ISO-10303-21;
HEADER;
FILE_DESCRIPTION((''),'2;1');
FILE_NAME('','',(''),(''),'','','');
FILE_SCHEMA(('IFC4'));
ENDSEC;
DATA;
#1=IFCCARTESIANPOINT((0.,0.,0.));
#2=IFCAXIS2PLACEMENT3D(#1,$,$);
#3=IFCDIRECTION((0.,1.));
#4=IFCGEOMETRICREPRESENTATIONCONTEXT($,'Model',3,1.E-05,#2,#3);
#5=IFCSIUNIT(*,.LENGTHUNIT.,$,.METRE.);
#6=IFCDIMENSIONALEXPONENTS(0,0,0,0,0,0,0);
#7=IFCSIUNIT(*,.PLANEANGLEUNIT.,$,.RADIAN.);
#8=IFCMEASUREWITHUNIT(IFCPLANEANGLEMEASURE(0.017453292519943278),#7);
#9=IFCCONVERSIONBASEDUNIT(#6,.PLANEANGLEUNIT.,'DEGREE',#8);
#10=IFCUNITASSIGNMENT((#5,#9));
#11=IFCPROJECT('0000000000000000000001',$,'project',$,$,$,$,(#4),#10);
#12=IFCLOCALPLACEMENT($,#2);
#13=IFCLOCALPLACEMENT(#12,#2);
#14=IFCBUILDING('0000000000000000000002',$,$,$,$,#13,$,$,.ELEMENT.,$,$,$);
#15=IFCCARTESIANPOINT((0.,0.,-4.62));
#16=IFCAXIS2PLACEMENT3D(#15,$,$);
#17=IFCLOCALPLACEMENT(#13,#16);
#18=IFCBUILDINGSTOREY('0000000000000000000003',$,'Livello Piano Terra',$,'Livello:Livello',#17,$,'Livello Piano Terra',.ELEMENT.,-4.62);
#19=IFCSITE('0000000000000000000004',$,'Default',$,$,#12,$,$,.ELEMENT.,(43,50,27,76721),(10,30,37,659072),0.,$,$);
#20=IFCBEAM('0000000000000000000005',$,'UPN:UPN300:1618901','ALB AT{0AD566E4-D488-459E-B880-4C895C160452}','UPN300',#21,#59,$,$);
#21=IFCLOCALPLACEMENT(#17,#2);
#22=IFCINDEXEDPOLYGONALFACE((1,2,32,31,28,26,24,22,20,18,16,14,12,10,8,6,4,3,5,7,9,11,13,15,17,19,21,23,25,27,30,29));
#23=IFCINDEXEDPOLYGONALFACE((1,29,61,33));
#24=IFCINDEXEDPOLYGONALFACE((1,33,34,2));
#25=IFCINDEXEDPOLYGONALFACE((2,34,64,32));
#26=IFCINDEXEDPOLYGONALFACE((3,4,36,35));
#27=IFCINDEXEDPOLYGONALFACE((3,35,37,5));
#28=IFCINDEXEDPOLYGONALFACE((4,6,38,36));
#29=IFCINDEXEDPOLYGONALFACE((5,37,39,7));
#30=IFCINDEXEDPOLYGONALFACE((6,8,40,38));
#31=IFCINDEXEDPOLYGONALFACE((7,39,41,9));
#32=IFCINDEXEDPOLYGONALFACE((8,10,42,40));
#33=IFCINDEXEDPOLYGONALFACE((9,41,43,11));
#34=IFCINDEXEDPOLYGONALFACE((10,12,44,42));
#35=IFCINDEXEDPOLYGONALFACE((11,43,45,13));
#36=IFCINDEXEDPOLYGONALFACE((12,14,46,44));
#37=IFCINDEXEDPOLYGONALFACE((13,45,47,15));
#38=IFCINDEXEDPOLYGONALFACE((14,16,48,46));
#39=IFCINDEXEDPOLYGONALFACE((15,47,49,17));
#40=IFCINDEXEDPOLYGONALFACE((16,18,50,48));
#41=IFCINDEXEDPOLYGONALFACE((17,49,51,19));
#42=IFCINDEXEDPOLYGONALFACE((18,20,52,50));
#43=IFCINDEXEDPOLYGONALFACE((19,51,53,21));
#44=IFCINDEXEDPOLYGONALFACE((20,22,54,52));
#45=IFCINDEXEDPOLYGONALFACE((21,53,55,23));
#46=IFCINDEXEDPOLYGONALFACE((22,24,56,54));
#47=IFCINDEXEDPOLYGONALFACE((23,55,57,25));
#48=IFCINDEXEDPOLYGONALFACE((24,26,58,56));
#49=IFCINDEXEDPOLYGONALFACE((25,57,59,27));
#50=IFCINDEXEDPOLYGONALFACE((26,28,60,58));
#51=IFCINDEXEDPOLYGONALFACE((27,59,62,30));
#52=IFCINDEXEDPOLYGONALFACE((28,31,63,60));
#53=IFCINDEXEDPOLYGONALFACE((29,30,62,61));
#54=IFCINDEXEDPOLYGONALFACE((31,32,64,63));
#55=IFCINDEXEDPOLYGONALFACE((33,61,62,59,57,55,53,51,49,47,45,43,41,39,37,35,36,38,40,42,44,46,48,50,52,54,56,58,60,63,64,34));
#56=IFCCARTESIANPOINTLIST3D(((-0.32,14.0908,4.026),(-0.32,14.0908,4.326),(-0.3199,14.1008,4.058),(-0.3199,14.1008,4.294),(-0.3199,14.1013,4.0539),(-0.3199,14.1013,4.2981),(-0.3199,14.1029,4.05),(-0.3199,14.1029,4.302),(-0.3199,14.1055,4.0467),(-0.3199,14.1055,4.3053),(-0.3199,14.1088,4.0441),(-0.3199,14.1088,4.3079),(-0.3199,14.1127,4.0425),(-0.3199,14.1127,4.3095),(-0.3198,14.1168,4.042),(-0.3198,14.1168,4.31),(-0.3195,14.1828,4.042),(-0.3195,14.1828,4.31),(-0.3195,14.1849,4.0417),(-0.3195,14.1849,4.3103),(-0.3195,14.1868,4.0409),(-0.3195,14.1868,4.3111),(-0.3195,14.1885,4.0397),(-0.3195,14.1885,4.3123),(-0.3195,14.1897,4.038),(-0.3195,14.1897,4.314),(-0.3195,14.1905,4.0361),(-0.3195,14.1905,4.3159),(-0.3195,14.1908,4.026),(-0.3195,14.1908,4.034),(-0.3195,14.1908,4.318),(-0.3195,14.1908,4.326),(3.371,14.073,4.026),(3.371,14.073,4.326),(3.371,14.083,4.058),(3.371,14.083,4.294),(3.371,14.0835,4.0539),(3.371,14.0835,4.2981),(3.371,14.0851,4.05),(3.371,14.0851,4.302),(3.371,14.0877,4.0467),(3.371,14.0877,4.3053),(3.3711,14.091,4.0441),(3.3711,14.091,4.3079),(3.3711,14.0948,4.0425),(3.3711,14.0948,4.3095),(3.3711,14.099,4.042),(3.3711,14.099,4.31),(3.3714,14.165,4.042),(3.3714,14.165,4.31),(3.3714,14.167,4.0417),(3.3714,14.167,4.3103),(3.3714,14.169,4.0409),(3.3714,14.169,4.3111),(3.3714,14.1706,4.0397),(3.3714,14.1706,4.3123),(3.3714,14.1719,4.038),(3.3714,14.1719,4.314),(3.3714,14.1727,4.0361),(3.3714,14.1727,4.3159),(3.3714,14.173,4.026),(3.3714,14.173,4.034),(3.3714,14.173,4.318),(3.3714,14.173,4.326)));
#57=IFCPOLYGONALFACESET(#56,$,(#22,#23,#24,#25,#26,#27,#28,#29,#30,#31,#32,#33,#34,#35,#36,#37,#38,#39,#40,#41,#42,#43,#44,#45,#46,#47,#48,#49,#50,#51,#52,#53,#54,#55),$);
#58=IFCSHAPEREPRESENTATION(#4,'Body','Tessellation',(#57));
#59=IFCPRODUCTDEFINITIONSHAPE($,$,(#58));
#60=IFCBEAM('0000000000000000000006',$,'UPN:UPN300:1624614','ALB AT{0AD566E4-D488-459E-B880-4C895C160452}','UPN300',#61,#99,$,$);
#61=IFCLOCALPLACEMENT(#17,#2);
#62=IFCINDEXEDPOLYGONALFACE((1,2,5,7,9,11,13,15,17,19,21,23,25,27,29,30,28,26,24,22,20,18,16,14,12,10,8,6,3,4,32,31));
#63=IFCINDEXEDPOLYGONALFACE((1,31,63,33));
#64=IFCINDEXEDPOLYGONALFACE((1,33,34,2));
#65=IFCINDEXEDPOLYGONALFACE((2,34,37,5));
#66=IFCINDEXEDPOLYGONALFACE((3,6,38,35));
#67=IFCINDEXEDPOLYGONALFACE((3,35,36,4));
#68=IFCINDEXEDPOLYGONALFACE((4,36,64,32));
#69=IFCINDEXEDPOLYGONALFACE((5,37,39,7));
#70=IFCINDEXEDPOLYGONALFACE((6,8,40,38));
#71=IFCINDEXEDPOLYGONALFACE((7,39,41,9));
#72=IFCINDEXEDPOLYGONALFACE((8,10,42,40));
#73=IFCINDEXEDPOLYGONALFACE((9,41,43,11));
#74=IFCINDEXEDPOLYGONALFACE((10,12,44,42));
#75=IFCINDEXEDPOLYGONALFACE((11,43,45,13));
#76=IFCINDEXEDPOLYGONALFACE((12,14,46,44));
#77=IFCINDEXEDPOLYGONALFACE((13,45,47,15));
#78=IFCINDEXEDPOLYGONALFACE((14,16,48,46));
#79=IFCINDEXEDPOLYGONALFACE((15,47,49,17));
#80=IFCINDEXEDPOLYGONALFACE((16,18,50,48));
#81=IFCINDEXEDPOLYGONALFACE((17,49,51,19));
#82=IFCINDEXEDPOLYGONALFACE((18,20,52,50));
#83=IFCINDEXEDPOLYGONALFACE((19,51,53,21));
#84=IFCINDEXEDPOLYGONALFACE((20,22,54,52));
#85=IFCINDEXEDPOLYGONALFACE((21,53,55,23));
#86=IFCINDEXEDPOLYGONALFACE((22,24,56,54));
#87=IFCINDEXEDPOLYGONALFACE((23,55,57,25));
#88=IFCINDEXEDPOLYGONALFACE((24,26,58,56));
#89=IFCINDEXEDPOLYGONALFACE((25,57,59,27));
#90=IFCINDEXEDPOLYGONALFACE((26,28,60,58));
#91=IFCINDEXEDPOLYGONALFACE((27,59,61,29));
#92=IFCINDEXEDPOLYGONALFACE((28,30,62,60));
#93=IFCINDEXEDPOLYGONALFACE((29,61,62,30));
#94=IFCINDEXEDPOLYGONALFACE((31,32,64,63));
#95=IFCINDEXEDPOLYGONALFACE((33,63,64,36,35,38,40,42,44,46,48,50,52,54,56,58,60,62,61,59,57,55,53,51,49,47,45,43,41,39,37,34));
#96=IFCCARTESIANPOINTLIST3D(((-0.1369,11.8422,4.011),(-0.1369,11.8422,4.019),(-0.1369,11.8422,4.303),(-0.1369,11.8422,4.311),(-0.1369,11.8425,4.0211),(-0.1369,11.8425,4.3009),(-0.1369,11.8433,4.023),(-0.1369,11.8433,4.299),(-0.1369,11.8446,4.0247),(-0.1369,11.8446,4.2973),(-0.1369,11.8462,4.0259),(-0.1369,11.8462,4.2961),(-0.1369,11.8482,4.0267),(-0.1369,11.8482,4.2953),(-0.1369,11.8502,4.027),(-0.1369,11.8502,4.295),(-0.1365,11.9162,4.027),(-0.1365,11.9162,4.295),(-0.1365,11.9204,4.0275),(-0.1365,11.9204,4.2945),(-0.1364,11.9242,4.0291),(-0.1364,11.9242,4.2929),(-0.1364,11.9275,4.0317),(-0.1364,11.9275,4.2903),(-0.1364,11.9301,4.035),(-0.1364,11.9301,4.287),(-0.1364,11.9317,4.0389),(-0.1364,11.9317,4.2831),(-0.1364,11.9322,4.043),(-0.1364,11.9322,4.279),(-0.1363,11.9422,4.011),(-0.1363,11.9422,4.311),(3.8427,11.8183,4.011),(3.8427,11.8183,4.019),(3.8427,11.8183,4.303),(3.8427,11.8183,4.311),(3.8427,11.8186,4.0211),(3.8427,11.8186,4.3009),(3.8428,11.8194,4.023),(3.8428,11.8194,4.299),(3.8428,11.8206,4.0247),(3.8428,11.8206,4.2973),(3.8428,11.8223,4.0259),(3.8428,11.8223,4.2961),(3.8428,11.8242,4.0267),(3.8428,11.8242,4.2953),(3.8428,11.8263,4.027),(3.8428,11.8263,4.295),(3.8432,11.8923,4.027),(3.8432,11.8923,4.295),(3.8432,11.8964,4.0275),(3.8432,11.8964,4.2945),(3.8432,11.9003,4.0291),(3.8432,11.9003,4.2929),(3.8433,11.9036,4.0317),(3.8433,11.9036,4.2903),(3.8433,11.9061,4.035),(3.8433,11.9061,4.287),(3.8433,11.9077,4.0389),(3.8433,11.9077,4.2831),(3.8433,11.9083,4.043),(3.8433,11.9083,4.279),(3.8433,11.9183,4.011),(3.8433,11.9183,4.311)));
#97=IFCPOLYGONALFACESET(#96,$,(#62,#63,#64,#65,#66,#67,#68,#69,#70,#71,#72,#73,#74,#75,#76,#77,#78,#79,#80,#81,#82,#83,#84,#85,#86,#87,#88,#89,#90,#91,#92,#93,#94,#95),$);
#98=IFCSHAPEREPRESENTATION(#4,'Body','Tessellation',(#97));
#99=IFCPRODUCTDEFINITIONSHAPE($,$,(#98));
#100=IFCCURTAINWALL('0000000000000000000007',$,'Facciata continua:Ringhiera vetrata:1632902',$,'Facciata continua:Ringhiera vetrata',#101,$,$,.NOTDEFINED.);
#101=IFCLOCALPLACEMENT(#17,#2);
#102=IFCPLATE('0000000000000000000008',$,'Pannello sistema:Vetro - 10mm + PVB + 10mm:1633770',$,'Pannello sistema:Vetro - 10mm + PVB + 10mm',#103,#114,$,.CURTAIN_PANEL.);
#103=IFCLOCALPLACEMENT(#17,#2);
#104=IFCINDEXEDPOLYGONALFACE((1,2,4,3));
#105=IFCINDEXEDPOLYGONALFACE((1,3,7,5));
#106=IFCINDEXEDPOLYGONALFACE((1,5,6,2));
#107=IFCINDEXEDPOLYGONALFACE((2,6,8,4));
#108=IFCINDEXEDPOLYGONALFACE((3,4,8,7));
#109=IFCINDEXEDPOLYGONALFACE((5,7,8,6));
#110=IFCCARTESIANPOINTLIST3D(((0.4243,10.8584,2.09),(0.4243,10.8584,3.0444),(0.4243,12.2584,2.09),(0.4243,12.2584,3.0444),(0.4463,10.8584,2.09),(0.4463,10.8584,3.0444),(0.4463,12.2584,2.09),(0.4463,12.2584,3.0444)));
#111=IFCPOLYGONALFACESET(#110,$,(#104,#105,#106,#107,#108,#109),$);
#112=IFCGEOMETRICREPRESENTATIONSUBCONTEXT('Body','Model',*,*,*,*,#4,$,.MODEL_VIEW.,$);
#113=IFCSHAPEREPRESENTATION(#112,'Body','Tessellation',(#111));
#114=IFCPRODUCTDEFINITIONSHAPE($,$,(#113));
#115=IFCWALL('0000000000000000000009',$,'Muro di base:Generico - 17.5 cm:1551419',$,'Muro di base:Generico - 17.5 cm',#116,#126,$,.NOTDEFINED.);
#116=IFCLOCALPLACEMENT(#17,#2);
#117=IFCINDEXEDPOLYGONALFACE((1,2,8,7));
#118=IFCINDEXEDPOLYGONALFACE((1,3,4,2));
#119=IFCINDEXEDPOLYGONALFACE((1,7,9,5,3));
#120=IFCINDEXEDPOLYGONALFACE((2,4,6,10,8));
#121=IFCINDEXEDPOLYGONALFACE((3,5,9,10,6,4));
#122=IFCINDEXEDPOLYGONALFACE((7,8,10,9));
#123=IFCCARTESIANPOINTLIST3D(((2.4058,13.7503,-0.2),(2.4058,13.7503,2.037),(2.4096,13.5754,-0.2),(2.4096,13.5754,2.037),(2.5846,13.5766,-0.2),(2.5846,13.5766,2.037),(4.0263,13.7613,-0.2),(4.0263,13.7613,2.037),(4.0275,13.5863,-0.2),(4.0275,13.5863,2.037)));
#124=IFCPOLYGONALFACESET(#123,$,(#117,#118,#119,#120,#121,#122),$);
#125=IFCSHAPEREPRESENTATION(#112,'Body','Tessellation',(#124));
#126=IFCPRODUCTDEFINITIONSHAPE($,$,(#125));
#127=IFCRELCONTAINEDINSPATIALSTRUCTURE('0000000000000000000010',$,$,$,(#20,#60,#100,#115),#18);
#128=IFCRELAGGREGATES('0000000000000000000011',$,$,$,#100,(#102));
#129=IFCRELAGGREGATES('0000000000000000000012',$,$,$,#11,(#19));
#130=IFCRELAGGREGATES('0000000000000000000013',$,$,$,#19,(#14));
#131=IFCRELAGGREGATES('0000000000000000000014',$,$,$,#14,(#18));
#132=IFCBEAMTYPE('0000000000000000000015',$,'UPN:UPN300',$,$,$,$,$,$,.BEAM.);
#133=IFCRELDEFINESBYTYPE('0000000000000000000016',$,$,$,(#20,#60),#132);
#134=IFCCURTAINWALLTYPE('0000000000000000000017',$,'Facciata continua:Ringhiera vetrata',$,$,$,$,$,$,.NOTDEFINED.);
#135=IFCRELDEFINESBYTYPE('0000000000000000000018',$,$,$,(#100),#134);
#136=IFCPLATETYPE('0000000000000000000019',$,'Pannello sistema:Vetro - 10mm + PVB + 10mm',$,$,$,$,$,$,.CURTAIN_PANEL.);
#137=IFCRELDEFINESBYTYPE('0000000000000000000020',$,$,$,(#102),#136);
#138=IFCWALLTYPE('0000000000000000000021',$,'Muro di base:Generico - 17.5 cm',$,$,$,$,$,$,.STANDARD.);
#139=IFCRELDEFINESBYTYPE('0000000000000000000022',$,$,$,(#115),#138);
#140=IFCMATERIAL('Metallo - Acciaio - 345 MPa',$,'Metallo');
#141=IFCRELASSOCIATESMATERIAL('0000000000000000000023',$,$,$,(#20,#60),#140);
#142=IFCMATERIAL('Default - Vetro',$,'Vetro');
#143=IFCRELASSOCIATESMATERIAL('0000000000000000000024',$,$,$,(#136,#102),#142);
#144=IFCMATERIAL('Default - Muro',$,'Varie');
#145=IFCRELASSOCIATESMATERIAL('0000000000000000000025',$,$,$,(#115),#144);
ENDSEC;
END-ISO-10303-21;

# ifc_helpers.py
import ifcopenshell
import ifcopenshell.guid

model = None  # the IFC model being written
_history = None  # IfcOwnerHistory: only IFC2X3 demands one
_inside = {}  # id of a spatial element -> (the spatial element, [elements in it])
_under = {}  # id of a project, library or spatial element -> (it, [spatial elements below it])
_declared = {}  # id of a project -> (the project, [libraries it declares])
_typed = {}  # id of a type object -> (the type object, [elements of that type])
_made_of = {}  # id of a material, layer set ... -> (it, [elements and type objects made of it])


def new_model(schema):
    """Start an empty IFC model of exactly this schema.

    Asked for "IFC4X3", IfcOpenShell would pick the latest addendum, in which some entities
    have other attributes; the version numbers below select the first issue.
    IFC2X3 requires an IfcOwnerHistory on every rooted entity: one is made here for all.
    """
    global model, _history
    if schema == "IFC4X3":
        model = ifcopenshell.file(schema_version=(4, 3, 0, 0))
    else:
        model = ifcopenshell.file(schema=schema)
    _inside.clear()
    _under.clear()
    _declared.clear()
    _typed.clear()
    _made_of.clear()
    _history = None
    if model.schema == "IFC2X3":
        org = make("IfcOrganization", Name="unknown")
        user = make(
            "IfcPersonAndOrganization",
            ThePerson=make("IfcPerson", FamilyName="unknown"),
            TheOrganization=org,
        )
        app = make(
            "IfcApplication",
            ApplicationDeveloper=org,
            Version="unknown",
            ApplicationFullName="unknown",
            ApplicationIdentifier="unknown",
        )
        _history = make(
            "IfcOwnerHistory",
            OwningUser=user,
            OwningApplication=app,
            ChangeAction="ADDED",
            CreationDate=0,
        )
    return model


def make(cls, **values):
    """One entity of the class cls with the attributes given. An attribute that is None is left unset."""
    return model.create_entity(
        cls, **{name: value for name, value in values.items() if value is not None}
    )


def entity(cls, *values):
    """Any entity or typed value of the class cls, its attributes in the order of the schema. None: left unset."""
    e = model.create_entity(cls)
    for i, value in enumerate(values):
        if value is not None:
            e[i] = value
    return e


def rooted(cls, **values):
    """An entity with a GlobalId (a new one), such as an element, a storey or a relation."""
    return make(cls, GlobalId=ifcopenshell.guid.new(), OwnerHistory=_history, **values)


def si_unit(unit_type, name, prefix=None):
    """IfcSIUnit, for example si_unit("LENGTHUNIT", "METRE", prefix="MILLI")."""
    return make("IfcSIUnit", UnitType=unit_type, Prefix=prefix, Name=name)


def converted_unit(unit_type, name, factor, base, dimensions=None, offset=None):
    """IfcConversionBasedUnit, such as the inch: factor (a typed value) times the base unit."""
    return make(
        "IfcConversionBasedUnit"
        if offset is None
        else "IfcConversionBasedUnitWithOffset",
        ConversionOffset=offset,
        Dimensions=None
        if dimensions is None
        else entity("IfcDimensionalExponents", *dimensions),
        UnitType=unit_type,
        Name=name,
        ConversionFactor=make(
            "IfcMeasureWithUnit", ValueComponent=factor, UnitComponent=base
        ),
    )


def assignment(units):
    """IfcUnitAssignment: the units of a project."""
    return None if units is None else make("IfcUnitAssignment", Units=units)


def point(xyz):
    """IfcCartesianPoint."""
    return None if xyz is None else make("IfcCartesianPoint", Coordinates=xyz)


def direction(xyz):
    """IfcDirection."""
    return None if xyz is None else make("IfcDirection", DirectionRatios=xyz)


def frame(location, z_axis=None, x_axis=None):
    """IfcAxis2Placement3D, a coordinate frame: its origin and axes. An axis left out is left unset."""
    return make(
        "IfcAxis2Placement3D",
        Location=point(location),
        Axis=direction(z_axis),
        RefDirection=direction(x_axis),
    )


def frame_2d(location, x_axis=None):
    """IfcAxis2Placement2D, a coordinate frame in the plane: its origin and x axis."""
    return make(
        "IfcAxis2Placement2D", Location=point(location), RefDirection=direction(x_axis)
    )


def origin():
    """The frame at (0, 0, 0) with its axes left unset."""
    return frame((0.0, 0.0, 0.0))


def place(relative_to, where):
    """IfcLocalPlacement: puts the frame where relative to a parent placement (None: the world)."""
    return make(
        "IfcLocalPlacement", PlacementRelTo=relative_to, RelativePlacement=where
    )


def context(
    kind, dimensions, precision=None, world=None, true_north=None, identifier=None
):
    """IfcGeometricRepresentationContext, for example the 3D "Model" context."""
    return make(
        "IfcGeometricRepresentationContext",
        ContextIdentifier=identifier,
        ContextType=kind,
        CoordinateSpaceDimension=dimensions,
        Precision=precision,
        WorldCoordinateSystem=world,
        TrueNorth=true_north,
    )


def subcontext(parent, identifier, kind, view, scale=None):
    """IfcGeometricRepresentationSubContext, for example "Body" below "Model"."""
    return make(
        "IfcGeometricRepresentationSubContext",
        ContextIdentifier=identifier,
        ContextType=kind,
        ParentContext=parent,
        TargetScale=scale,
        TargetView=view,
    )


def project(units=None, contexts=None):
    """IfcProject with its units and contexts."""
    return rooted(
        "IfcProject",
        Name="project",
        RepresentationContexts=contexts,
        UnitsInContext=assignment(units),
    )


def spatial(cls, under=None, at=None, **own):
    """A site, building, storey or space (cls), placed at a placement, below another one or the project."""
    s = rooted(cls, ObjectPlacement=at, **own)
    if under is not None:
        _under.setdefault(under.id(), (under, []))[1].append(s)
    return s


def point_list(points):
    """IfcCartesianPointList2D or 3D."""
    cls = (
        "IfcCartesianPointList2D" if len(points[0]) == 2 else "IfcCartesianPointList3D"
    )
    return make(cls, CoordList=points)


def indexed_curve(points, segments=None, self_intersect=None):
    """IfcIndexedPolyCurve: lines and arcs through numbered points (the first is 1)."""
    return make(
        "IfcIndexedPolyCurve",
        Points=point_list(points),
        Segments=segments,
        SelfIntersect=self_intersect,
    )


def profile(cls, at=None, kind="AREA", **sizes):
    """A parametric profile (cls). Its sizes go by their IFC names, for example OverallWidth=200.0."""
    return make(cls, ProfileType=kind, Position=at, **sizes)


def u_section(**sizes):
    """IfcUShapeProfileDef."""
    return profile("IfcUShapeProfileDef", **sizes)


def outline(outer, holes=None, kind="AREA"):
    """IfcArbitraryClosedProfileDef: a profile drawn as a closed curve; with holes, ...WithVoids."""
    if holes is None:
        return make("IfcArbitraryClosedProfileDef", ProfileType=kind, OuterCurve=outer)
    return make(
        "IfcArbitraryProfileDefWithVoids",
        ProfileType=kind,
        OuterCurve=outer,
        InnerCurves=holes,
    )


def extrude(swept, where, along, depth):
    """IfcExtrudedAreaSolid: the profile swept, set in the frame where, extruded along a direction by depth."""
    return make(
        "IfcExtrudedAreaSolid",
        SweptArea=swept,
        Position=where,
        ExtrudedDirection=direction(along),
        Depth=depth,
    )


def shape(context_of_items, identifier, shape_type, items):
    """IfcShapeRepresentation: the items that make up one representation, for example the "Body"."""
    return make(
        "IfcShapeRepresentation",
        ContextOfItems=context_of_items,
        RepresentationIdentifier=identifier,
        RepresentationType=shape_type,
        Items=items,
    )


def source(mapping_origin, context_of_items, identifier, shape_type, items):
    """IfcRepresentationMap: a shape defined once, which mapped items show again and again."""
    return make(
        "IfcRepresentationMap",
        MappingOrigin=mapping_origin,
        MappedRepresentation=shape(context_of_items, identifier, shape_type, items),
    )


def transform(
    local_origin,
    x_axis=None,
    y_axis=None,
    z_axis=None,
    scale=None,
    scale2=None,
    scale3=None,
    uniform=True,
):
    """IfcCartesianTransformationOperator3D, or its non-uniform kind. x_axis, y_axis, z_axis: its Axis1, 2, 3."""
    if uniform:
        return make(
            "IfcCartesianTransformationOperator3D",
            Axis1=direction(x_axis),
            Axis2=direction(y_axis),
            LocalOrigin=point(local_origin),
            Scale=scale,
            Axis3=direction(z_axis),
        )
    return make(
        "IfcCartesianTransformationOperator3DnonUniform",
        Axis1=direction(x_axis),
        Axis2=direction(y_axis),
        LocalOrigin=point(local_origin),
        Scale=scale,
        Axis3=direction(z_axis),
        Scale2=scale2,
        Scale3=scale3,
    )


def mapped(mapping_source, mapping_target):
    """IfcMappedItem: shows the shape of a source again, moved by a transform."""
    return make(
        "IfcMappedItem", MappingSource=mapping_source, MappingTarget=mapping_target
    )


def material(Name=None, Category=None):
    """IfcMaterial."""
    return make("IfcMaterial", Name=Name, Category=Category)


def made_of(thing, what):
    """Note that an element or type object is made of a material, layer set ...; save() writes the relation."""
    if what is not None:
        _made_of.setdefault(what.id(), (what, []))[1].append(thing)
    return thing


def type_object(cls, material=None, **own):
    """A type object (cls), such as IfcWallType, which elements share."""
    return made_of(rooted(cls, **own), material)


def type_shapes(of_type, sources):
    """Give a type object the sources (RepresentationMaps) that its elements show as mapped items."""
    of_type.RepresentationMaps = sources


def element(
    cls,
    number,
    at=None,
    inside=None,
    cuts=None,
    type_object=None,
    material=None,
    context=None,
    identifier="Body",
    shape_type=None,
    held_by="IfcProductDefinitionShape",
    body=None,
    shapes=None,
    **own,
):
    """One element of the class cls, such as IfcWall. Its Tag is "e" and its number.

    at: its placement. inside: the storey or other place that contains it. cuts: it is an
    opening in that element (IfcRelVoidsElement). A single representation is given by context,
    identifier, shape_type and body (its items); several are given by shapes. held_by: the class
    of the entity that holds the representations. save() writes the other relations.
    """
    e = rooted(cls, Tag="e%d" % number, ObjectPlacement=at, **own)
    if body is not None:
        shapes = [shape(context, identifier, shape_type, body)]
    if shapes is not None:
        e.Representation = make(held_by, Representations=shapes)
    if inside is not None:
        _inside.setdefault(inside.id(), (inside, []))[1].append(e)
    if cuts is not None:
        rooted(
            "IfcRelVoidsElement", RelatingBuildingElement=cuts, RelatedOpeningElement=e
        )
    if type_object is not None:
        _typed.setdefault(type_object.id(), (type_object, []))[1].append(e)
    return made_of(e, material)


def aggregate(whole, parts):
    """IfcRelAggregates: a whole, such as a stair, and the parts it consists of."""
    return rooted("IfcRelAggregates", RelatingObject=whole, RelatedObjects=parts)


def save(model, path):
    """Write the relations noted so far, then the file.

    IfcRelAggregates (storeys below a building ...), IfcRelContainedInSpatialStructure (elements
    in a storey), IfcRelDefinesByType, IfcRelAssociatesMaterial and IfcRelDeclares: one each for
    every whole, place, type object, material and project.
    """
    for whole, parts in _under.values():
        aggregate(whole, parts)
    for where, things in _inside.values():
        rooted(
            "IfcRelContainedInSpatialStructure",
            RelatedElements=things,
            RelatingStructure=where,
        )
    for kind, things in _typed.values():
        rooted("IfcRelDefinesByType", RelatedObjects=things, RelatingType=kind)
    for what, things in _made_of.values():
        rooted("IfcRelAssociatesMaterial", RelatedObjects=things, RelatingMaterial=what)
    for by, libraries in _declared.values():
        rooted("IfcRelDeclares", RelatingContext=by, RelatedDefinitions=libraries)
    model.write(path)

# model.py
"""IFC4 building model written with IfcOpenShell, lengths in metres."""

from ifc_helpers import new_model, entity, si_unit, converted_unit, direction, frame, frame_2d, origin, place, context, subcontext, project, spatial, indexed_curve, u_section, outline, extrude, source, transform, mapped, material, type_object, type_shapes, element, aggregate, save


model = new_model("IFC4")

# Units and contexts
model_context = context("Model", 3, precision=1e-05, world=origin(), true_north=direction((0.0, 1.0)))
body_context = subcontext(model_context, "Body", "Model", "MODEL_VIEW")
ifc_project = project(units=[si_unit("LENGTHUNIT", "METRE"), converted_unit("PLANEANGLEUNIT", "DEGREE", entity("IfcPlaneAngleMeasure", 0.017453292519943278), si_unit("PLANEANGLEUNIT", "RADIAN"), dimensions=[0, 0, 0, 0, 0, 0, 0])], contexts=[model_context])

# Site, building, storey
site_placement = place(None, origin())
site = spatial("IfcSite", under=ifc_project, at=site_placement, Name="Default", CompositionType="ELEMENT", RefLatitude=(43, 50, 27, 76721), RefLongitude=(10, 30, 37, 659072), RefElevation=0.0)
building_placement = place(site_placement, origin())
building = spatial("IfcBuilding", under=site, at=building_placement, CompositionType="ELEMENT")
storey_placement = place(building_placement, frame((0.0, 0.0, -4.62)))
storey = spatial("IfcBuildingStorey", under=building, at=storey_placement, Name="Livello Piano Terra", ObjectType="Livello:Livello", LongName="Livello Piano Terra", CompositionType="ELEMENT", Elevation=-4.62)

# Beams
ifc_material_1 = material(Name="Metallo - Acciaio - 345 MPa", Category="Metallo")
beam_type_1 = type_object("IfcBeamType", Name="UPN:UPN300", PredefinedType="BEAM")
beam_1_placement = place(storey_placement, frame((3.3711, 14.1, 4.176), z_axis=(0.999988, -0.00483, 0.0), x_axis=(0.00483, 0.999988, 0.0)))
element("IfcBeam", 1, at=beam_1_placement, inside=storey, type_object=beam_type_1, material=ifc_material_1, Name="UPN:UPN300:1618901", Description="ALB AT{0AD566E4-D488-459E-B880-4C895C160452}", ObjectType="UPN300", context=model_context, shape_type="SweptSolid", body=[
    extrude(u_section(Depth=0.3, FlangeWidth=0.1, WebThickness=0.01, FlangeThickness=0.016, FilletRadius=0.016, EdgeRadius=0.008, FlangeSlope=0.00457, at=frame_2d((0.023, 0.0))), origin(), (0.0, 0.0, -1.0), 3.691),
])
beam_2_placement = place(storey_placement, frame((3.8432, 11.8913, 4.161), z_axis=(-0.999982, 0.006016, 0.0), x_axis=(-0.006016, -0.999982, 0.0)))
element("IfcBeam", 2, at=beam_2_placement, inside=storey, type_object=beam_type_1, material=ifc_material_1, Name="UPN:UPN300:1624614", Description="ALB AT{0AD566E4-D488-459E-B880-4C895C160452}", ObjectType="UPN300", context=model_context, shape_type="SweptSolid", body=[
    extrude(u_section(Depth=0.3, FlangeWidth=0.1, WebThickness=0.01, FlangeThickness=0.016, FilletRadius=0.016, EdgeRadius=0.008, FlangeSlope=0.00457, at=frame_2d((0.023, 0.0))), origin(), (0.0, 0.0, 1.0), 3.9797),
])

# Curtain wall, plate
curtain_wall_type = type_object("IfcCurtainWallType", Name="Facciata continua:Ringhiera vetrata", PredefinedType="NOTDEFINED")
curtain_wall_placement = place(storey_placement, frame((0.0, 0.0, 4.62)))
curtain_wall = element("IfcCurtainWall", 3, at=curtain_wall_placement, inside=storey, type_object=curtain_wall_type, Name="Facciata continua:Ringhiera vetrata:1632902", ObjectType="Facciata continua:Ringhiera vetrata", PredefinedType="NOTDEFINED")
ifc_material_2 = material(Name="Default - Vetro", Category="Vetro")
plate_type = type_object("IfcPlateType", Name="Pannello sistema:Vetro - 10mm + PVB + 10mm", PredefinedType="CURTAIN_PANEL", material=ifc_material_2)
shared_shape_1 = source(origin(), body_context, "Body", "SweptSolid", [
    extrude(outline(indexed_curve([(-0.011, -0.7), (0.011, -0.7), (0.011, 0.7), (-0.011, 0.7), (-0.011, -0.7)], self_intersect=False)), frame((0.0, 0.0, 0.0), z_axis=(0.0, 0.0, 1.0), x_axis=(0.0, 1.0, 0.0)), (0.0, 0.0, 1.0), 0.9544),
])
type_shapes(plate_type, [shared_shape_1])
plate_placement = place(curtain_wall_placement, frame((0.4353, 11.5584, -2.53), z_axis=(0.0, 0.0, 1.0), x_axis=(0.0, 1.0, 0.0)))
plate = element("IfcPlate", 4, at=plate_placement, type_object=plate_type, material=ifc_material_2, Name="Pannello sistema:Vetro - 10mm + PVB + 10mm:1633770", ObjectType="Pannello sistema:Vetro - 10mm + PVB + 10mm", PredefinedType="CURTAIN_PANEL", context=body_context, shape_type="MappedRepresentation", body=[
    mapped(shared_shape_1, transform((0.0, 0.0, 0.0), scale=1.0)),
])
aggregate(curtain_wall, [plate])

# Wall
ifc_material_3 = material(Name="Default - Muro", Category="Varie")
wall_type = type_object("IfcWallType", Name="Muro di base:Generico - 17.5 cm", PredefinedType="STANDARD")
wall_placement = place(storey_placement, frame((2.4064, 13.6629, -0.2), z_axis=(0.0, 0.0, 1.0), x_axis=(0.999977, 0.006784, 0.0)))
element("IfcWall", 5, at=wall_placement, inside=storey, type_object=wall_type, material=ifc_material_3, Name="Muro di base:Generico - 17.5 cm:1551419", ObjectType="Muro di base:Generico - 17.5 cm", PredefinedType="NOTDEFINED", context=body_context, shape_type="SweptSolid", body=[
    extrude(outline(indexed_curve([(1.6205, -0.0875), (1.6205, 0.0875), (0.0, 0.0875), (0.0026, -0.0875), (0.1776, -0.0875), (1.6205, -0.0875)], self_intersect=False)), origin(), (0.0, 0.0, 1.0), 2.237),
])

save(model, "model.ifc")
